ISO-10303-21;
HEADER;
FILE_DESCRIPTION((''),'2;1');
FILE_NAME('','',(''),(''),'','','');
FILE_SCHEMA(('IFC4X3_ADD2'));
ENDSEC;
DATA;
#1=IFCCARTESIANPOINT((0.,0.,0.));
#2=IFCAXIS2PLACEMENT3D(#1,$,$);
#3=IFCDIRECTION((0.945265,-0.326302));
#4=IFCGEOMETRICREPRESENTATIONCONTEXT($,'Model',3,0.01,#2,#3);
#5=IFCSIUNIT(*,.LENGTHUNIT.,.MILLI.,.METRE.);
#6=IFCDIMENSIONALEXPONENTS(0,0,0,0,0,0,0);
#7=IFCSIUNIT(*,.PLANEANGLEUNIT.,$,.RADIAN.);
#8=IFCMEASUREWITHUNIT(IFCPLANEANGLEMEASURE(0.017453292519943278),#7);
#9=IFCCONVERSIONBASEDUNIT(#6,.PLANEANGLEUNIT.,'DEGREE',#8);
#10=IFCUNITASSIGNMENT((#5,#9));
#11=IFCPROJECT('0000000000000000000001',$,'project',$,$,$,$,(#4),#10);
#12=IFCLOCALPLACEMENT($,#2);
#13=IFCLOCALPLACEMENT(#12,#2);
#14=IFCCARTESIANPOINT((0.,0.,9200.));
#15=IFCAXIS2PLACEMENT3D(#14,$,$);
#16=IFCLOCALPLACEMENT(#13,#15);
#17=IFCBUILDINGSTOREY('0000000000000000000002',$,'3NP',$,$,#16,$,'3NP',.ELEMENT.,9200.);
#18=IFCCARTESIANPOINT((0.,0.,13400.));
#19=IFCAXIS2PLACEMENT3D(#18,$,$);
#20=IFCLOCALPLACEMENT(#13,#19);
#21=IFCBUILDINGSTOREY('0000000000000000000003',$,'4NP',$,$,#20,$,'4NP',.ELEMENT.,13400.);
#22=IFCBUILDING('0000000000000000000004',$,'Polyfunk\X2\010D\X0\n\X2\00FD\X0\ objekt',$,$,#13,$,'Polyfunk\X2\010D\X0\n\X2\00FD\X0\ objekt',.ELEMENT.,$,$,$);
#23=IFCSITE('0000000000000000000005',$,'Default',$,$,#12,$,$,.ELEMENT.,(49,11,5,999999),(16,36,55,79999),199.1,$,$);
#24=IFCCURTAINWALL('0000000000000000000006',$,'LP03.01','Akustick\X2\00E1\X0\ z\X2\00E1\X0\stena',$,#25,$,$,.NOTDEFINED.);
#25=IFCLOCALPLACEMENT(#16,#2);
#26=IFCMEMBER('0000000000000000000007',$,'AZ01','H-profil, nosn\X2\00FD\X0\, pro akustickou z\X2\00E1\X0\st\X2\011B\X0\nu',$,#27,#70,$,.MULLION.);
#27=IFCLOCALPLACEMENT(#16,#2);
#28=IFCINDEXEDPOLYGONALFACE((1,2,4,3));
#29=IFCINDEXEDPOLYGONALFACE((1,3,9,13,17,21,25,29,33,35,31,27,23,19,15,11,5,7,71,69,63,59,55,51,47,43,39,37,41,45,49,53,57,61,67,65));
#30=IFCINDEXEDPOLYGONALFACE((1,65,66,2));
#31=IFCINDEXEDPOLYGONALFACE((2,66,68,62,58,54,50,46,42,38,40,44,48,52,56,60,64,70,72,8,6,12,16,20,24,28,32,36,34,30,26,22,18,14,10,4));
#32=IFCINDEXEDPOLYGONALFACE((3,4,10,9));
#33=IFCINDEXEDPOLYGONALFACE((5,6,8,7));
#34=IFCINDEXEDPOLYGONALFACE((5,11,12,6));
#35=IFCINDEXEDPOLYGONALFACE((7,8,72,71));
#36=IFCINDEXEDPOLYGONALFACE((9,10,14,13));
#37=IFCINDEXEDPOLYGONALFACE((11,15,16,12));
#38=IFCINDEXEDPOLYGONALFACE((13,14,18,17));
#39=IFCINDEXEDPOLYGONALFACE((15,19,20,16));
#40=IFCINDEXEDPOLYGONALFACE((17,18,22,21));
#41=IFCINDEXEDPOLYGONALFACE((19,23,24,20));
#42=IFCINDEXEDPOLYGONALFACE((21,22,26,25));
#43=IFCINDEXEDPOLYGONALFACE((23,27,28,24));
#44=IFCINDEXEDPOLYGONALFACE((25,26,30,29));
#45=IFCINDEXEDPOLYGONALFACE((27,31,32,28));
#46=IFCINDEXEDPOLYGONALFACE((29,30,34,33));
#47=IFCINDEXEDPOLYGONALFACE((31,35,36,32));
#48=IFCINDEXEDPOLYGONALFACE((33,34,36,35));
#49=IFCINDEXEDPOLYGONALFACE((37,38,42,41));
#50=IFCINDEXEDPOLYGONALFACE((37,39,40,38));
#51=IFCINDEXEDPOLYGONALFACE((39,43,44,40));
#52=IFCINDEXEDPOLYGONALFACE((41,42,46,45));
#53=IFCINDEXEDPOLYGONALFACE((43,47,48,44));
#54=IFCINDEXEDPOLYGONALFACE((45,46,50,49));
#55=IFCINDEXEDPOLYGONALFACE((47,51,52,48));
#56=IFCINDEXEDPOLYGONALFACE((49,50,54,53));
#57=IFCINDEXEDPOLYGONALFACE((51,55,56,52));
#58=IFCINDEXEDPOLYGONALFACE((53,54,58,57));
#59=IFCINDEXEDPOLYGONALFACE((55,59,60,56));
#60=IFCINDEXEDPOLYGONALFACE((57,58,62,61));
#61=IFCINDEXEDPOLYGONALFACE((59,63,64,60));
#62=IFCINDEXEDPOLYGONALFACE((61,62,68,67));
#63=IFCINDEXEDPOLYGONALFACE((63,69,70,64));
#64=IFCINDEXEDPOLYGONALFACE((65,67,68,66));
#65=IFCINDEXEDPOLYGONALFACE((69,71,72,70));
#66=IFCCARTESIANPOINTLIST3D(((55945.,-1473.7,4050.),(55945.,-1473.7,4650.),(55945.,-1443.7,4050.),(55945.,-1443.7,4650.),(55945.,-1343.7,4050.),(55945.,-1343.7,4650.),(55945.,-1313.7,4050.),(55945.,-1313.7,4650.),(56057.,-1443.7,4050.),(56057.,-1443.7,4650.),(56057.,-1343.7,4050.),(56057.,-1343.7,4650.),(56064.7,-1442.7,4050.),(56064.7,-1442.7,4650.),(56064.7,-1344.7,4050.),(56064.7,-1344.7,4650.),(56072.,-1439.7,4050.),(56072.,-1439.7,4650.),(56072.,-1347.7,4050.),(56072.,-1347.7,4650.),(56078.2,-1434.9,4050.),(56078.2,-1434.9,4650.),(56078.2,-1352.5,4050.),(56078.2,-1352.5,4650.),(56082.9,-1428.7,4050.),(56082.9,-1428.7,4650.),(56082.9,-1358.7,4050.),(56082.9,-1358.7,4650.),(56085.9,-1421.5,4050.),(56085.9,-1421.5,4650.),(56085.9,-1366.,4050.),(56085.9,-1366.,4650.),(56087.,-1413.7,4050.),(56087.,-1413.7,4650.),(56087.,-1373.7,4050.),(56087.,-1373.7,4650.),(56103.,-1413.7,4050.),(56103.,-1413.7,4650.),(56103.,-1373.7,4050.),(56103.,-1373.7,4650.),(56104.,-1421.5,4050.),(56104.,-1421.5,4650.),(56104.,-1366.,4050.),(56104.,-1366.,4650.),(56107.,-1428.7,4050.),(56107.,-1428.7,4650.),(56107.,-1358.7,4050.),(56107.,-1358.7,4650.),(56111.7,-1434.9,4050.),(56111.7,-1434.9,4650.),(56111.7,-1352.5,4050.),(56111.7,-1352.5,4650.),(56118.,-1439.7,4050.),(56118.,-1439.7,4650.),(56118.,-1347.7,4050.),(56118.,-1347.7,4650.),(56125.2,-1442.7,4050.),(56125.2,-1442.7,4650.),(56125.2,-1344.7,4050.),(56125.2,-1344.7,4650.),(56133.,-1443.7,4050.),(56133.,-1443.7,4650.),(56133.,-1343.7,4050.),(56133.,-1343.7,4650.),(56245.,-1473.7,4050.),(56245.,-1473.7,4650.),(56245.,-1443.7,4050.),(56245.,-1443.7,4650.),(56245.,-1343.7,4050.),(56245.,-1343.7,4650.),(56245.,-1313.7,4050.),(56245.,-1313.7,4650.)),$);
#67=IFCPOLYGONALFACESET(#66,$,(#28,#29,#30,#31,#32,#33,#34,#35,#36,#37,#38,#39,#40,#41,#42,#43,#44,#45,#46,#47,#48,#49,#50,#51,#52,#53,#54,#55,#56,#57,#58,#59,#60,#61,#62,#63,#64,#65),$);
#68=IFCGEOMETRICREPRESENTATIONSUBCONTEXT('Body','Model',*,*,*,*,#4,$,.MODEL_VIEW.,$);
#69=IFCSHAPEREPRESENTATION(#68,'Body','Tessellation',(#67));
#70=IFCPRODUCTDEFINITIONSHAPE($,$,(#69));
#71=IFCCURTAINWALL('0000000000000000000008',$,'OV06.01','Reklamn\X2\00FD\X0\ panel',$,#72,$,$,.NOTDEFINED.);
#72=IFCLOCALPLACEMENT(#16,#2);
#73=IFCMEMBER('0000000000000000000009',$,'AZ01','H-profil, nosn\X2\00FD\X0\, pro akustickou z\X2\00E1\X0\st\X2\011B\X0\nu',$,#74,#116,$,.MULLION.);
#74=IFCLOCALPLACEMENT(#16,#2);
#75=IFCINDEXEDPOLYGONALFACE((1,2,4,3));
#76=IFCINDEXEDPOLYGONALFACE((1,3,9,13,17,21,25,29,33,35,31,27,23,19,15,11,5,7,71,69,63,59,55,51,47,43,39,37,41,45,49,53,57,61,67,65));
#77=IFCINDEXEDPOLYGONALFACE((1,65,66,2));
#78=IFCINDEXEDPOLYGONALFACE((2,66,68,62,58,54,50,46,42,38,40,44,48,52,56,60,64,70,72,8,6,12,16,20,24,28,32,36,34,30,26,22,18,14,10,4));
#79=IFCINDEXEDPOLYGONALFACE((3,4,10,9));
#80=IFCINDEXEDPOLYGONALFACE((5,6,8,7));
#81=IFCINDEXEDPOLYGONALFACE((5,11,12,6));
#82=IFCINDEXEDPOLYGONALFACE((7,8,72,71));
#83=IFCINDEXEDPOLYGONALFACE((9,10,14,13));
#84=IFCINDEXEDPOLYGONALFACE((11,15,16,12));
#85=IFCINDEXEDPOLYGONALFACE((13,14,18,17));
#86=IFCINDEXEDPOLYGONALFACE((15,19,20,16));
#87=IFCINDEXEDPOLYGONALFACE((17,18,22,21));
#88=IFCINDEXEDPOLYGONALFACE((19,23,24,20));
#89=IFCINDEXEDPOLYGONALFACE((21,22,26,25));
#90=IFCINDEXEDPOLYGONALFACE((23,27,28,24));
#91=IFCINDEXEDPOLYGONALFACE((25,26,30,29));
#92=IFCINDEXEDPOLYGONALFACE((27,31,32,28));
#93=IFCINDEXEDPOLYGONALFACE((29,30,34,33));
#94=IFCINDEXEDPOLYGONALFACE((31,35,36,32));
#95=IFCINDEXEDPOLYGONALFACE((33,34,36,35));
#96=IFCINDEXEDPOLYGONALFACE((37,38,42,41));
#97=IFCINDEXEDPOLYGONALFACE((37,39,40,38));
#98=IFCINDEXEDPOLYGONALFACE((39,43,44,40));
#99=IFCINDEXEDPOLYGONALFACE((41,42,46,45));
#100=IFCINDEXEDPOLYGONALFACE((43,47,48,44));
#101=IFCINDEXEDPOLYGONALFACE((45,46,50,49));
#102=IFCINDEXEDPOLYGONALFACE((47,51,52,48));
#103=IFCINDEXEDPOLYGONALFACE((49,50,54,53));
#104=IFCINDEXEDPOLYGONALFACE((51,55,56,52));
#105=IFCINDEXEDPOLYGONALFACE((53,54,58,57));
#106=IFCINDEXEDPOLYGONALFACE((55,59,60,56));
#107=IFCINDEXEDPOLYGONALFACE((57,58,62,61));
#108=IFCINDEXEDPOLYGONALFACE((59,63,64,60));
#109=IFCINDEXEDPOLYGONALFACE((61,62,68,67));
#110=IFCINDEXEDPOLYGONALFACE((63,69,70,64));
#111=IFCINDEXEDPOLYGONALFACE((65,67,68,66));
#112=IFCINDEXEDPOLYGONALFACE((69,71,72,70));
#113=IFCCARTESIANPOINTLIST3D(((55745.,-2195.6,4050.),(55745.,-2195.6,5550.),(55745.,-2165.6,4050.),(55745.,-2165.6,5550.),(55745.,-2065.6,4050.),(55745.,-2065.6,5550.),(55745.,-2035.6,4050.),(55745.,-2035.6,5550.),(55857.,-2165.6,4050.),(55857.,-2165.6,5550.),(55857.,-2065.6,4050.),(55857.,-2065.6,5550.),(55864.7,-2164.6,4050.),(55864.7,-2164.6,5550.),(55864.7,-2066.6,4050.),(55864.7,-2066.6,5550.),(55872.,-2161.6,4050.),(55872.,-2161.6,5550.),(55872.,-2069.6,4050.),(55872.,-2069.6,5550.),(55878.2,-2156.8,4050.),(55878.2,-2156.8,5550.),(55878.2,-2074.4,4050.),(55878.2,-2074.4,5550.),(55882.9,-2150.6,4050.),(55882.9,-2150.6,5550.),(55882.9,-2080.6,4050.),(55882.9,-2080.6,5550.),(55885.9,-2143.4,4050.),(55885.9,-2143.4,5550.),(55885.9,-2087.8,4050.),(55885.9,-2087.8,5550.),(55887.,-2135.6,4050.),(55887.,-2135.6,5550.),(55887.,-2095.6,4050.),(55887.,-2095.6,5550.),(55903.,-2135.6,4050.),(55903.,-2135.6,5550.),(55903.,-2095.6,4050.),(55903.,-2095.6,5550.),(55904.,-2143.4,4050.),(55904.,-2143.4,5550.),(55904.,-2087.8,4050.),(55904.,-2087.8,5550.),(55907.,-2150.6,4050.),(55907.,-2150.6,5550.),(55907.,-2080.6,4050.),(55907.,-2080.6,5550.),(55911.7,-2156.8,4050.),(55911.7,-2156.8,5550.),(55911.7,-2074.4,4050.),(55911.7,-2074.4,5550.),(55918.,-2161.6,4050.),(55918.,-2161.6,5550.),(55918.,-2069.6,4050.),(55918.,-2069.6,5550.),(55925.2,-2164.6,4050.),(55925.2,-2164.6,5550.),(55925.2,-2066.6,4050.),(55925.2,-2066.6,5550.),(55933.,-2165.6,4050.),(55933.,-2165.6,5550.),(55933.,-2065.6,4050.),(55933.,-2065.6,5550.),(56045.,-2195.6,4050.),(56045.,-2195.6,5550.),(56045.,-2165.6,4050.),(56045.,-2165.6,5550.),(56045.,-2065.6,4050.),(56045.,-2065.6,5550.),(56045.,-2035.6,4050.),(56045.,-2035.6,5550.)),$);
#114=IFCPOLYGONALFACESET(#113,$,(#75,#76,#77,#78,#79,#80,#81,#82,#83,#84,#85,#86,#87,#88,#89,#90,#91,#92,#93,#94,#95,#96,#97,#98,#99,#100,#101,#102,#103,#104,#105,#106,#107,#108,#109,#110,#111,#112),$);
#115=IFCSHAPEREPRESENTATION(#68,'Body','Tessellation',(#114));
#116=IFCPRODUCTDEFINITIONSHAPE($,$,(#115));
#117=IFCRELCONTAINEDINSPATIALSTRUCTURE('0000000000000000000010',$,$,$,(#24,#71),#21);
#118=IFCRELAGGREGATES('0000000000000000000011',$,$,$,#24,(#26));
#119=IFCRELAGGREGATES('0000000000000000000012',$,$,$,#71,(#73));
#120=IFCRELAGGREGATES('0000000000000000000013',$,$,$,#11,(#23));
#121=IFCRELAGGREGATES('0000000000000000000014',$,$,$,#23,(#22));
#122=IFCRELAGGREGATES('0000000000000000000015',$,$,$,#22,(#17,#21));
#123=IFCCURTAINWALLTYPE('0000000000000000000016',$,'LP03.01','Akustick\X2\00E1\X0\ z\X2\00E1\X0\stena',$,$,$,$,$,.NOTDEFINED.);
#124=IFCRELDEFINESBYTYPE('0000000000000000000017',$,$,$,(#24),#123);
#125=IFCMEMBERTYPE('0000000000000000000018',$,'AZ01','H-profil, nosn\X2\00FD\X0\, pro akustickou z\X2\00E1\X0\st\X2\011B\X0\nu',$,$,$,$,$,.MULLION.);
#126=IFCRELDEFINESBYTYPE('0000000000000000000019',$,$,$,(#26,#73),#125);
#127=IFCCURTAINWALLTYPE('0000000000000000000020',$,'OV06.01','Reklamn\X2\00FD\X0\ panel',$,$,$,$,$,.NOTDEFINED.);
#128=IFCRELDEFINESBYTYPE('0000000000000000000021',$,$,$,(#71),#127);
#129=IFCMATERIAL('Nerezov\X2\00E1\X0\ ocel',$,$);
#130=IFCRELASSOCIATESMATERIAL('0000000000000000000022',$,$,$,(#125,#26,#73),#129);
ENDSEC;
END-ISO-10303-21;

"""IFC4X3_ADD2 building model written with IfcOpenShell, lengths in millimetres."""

from ifc_helpers import new_model, entity, si_unit, converted_unit, direction, frame, frame_2d, origin, place, context, subcontext, project, spatial, polyline, circle_curve, parameter, trimmed, segment, composite_curve, outline, extrude, source, transform, mapped, material, material_profile, profile_set, profile_usage, type_object, element, aggregate, save


model = new_model("IFC4X3_ADD2")

# Units and contexts
model_context = context("Model", 3, precision=0.01, world=origin(), true_north=direction((0.945265, -0.326302)))
body_context = subcontext(model_context, "Body", "Model", "MODEL_VIEW")
ifc_project = project(units=[si_unit("LENGTHUNIT", "METRE", prefix="MILLI"), converted_unit("PLANEANGLEUNIT", "DEGREE", entity("IfcPlaneAngleMeasure", 0.017453292519943278), si_unit("PLANEANGLEUNIT", "RADIAN"), dimensions=[0, 0, 0, 0, 0, 0, 0])], contexts=[model_context])

# Site, building, storey
site_placement = place(None, origin())
site = spatial("IfcSite", under=ifc_project, at=site_placement, Name="Default", CompositionType="ELEMENT", RefLatitude=(49, 11, 5, 999999), RefLongitude=(16, 36, 55, 79999), RefElevation=199.1)
building_placement = place(site_placement, origin())
building = spatial("IfcBuilding", under=site, at=building_placement, Name="Polyfunkčný objekt", LongName="Polyfunkčný objekt", CompositionType="ELEMENT")
storey_1_placement = place(building_placement, frame((0.0, 0.0, 9200.0)))
storey_1 = spatial("IfcBuildingStorey", under=building, at=storey_1_placement, Name="3NP", LongName="3NP", CompositionType="ELEMENT", Elevation=9200.0)

# Shared definitions
storey_2_placement = place(building_placement, frame((0.0, 0.0, 13400.0)))
storey_2 = spatial("IfcBuildingStorey", under=building, at=storey_2_placement, Name="4NP", LongName="4NP", CompositionType="ELEMENT", Elevation=13400.0)

# Curtain walls, members
curtain_wall_type_1 = type_object("IfcCurtainWallType", Name="LP03.01", Description="Akustická zástena", PredefinedType="NOTDEFINED")
curtain_wall_1_placement = place(storey_2_placement, frame((0.0, 0.0, -13400.0)))
curtain_wall_1 = element("IfcCurtainWall", 1, at=curtain_wall_1_placement, inside=storey_2, type_object=curtain_wall_type_1, Name="LP03.01", Description="Akustická zástena", PredefinedType="NOTDEFINED")
ifc_material_1 = material(Name="Nerezová ocel")
ifc_material_profile_1 = material_profile(ifc_material_1, outline(composite_curve([segment(polyline([(50.0, -150.0), (80.0, -150.0)]), True, "CONTINUOUS"), segment(polyline([(80.0, -150.0), (80.0, 150.0)]), True, "CONTINUOUS"), segment(polyline([(80.0, 150.0), (50.0, 150.0)]), True, "CONTINUOUS"), segment(polyline([(50.0, 150.0), (50.0, 38.0)]), True, "CONTINUOUS"), segment(trimmed(circle_curve(frame_2d((20.0, 38.0), x_axis=(0.0, 1.0)), 30.0), [parameter(180.0)], [parameter(270.0)], True, "PARAMETER"), False, "CONTINUOUS"), segment(polyline([(20.0, 8.0), (-20.0, 8.0)]), True, "CONTINUOUS"), segment(trimmed(circle_curve(frame_2d((-20.0, 38.0), x_axis=(0.0, 1.0)), 30.0), [parameter(90.0)], [parameter(180.0)], True, "PARAMETER"), False, "CONTINUOUS"), segment(polyline([(-50.0, 38.0), (-50.0, 150.0)]), True, "CONTINUOUS"), segment(polyline([(-50.0, 150.0), (-80.0, 150.0)]), True, "CONTINUOUS"), segment(polyline([(-80.0, 150.0), (-80.0, -150.0)]), True, "CONTINUOUS"), segment(polyline([(-80.0, -150.0), (-50.0, -150.0)]), True, "CONTINUOUS"), segment(polyline([(-50.0, -150.0), (-50.0, -38.0)]), True, "CONTINUOUS"), segment(trimmed(circle_curve(frame_2d((-20.0, -38.0), x_axis=(0.0, 1.0)), 30.0), [parameter(0.0)], [parameter(90.0)], True, "PARAMETER"), False, "CONTINUOUS"), segment(polyline([(-20.0, -8.0), (20.0, -8.0)]), True, "CONTINUOUS"), segment(trimmed(circle_curve(frame_2d((20.0, -38.0), x_axis=(0.0, 1.0)), 30.0), [parameter(270.0)], [parameter(0.0)], True, "PARAMETER"), False, "CONTINUOUS"), segment(polyline([(50.0, -38.0), (50.0, -150.0)]), True, "CONTINUOUS")], self_intersect=False)), Name="Profil zástena")
ifc_profile_set_1 = profile_set([ifc_material_profile_1], Name="Profil zástena")
ifc_profile_usage_1 = profile_usage(ifc_profile_set_1)
member_type_1 = type_object("IfcMemberType", Name="AZ01", Description="H-profil, nosný, pro akustickou zástěnu", PredefinedType="MULLION", material=ifc_profile_set_1)
shared_shape_1 = source(origin(), body_context, "Body", "SweptSolid", [
    extrude(outline(composite_curve([segment(polyline([(50.0, -150.0), (80.0, -150.0)]), True, "CONTINUOUS"), segment(polyline([(80.0, -150.0), (80.0, 150.0)]), True, "CONTINUOUS"), segment(polyline([(80.0, 150.0), (50.0, 150.0)]), True, "CONTINUOUS"), segment(polyline([(50.0, 150.0), (50.0, 38.0)]), True, "CONTINUOUS"), segment(trimmed(circle_curve(frame_2d((20.0, 38.0), x_axis=(0.0, 1.0)), 30.0), [parameter(180.0)], [parameter(270.0)], True, "PARAMETER"), False, "CONTINUOUS"), segment(polyline([(20.0, 8.0), (-20.0, 8.0)]), True, "CONTINUOUS"), segment(trimmed(circle_curve(frame_2d((-20.0, 38.0), x_axis=(0.0, 1.0)), 30.0), [parameter(90.0)], [parameter(180.0)], True, "PARAMETER"), False, "CONTINUOUS"), segment(polyline([(-50.0, 38.0), (-50.0, 150.0)]), True, "CONTINUOUS"), segment(polyline([(-50.0, 150.0), (-80.0, 150.0)]), True, "CONTINUOUS"), segment(polyline([(-80.0, 150.0), (-80.0, -150.0)]), True, "CONTINUOUS"), segment(polyline([(-80.0, -150.0), (-50.0, -150.0)]), True, "CONTINUOUS"), segment(polyline([(-50.0, -150.0), (-50.0, -38.0)]), True, "CONTINUOUS"), segment(trimmed(circle_curve(frame_2d((-20.0, -38.0), x_axis=(0.0, 1.0)), 30.0), [parameter(0.0)], [parameter(90.0)], True, "PARAMETER"), False, "CONTINUOUS"), segment(polyline([(-20.0, -8.0), (20.0, -8.0)]), True, "CONTINUOUS"), segment(trimmed(circle_curve(frame_2d((20.0, -38.0), x_axis=(0.0, 1.0)), 30.0), [parameter(270.0)], [parameter(0.0)], True, "PARAMETER"), False, "CONTINUOUS"), segment(polyline([(50.0, -38.0), (50.0, -150.0)]), True, "CONTINUOUS")], self_intersect=False)), frame((-150.0, 0.0, -600.0), z_axis=(0.0, 0.0, 1.0), x_axis=(0.0, -1.0, 0.0)), (0.0, 0.0, 1.0), 600.0),
])
member_1_placement = place(curtain_wall_1_placement, frame((56245.0, -1393.7, 13250.0), z_axis=(0.0, 0.0, -1.0), x_axis=(1.0, 0.0, 0.0)))
member_1 = element("IfcMember", 2, at=member_1_placement, type_object=member_type_1, material=ifc_profile_usage_1, Name="AZ01", Description="H-profil, nosný, pro akustickou zástěnu", PredefinedType="MULLION", context=body_context, shape_type="MappedRepresentation", body=[
    mapped(shared_shape_1, transform((0.0, 0.0, 0.0), scale=1.0)),
])
aggregate(curtain_wall_1, [member_1])
curtain_wall_type_2 = type_object("IfcCurtainWallType", Name="OV06.01", Description="Reklamný panel", PredefinedType="NOTDEFINED")
curtain_wall_2_placement = place(storey_2_placement, frame((0.0, 0.0, -13400.0)))
curtain_wall_2 = element("IfcCurtainWall", 3, at=curtain_wall_2_placement, inside=storey_2, type_object=curtain_wall_type_2, Name="OV06.01", Description="Reklamný panel", PredefinedType="NOTDEFINED")
shared_shape_2 = source(origin(), body_context, "Body", "SweptSolid", [
    extrude(outline(composite_curve([segment(polyline([(-150.0, -50.0), (-150.0, -80.0)]), True, "CONTINUOUS"), segment(polyline([(-150.0, -80.0), (150.0, -80.0)]), True, "CONTINUOUS"), segment(polyline([(150.0, -80.0), (150.0, -50.0)]), True, "CONTINUOUS"), segment(polyline([(150.0, -50.0), (38.0, -50.0)]), True, "CONTINUOUS"), segment(trimmed(circle_curve(frame_2d((38.0, -20.0), x_axis=(1.0, 0.0)), 30.0), [parameter(180.0)], [parameter(270.0)], True, "PARAMETER"), False, "CONTINUOUS"), segment(polyline([(8.0, -20.0), (8.0, 20.0)]), True, "CONTINUOUS"), segment(trimmed(circle_curve(frame_2d((38.0, 20.0), x_axis=(1.0, 0.0)), 30.0), [parameter(90.0)], [parameter(180.0)], True, "PARAMETER"), False, "CONTINUOUS"), segment(polyline([(38.0, 50.0), (150.0, 50.0)]), True, "CONTINUOUS"), segment(polyline([(150.0, 50.0), (150.0, 80.0)]), True, "CONTINUOUS"), segment(polyline([(150.0, 80.0), (-150.0, 80.0)]), True, "CONTINUOUS"), segment(polyline([(-150.0, 80.0), (-150.0, 50.0)]), True, "CONTINUOUS"), segment(polyline([(-150.0, 50.0), (-38.0, 50.0)]), True, "CONTINUOUS"), segment(trimmed(circle_curve(frame_2d((-38.0, 20.0), x_axis=(1.0, 0.0)), 30.0), [parameter(0.0)], [parameter(90.0)], True, "PARAMETER"), False, "CONTINUOUS"), segment(polyline([(-8.0, 20.0), (-8.0, -20.0)]), True, "CONTINUOUS"), segment(trimmed(circle_curve(frame_2d((-38.0, -20.0), x_axis=(1.0, 0.0)), 30.0), [parameter(270.0)], [parameter(0.0)], True, "PARAMETER"), False, "CONTINUOUS"), segment(polyline([(-38.0, -50.0), (-150.0, -50.0)]), True, "CONTINUOUS")], self_intersect=False)), frame((-150.0, 0.0, -1500.0), z_axis=(0.0, 0.0, -1.0), x_axis=(1.0, 0.0, 0.0)), (0.0, 0.0, -1.0), 1500.0),
])
member_2_placement = place(curtain_wall_2_placement, frame((56045.0, -2115.6, 13250.0), z_axis=(0.0, 0.0, -1.0), x_axis=(1.0, 0.0, 0.0)))
member_2 = element("IfcMember", 4, at=member_2_placement, type_object=member_type_1, material=ifc_profile_usage_1, Name="AZ01", Description="H-profil, nosný, pro akustickou zástěnu", PredefinedType="MULLION", context=body_context, shape_type="MappedRepresentation", body=[
    mapped(shared_shape_2, transform((0.0, 0.0, 0.0), scale=1.0)),
])
aggregate(curtain_wall_2, [member_2])

save(model, "model.ifc")
